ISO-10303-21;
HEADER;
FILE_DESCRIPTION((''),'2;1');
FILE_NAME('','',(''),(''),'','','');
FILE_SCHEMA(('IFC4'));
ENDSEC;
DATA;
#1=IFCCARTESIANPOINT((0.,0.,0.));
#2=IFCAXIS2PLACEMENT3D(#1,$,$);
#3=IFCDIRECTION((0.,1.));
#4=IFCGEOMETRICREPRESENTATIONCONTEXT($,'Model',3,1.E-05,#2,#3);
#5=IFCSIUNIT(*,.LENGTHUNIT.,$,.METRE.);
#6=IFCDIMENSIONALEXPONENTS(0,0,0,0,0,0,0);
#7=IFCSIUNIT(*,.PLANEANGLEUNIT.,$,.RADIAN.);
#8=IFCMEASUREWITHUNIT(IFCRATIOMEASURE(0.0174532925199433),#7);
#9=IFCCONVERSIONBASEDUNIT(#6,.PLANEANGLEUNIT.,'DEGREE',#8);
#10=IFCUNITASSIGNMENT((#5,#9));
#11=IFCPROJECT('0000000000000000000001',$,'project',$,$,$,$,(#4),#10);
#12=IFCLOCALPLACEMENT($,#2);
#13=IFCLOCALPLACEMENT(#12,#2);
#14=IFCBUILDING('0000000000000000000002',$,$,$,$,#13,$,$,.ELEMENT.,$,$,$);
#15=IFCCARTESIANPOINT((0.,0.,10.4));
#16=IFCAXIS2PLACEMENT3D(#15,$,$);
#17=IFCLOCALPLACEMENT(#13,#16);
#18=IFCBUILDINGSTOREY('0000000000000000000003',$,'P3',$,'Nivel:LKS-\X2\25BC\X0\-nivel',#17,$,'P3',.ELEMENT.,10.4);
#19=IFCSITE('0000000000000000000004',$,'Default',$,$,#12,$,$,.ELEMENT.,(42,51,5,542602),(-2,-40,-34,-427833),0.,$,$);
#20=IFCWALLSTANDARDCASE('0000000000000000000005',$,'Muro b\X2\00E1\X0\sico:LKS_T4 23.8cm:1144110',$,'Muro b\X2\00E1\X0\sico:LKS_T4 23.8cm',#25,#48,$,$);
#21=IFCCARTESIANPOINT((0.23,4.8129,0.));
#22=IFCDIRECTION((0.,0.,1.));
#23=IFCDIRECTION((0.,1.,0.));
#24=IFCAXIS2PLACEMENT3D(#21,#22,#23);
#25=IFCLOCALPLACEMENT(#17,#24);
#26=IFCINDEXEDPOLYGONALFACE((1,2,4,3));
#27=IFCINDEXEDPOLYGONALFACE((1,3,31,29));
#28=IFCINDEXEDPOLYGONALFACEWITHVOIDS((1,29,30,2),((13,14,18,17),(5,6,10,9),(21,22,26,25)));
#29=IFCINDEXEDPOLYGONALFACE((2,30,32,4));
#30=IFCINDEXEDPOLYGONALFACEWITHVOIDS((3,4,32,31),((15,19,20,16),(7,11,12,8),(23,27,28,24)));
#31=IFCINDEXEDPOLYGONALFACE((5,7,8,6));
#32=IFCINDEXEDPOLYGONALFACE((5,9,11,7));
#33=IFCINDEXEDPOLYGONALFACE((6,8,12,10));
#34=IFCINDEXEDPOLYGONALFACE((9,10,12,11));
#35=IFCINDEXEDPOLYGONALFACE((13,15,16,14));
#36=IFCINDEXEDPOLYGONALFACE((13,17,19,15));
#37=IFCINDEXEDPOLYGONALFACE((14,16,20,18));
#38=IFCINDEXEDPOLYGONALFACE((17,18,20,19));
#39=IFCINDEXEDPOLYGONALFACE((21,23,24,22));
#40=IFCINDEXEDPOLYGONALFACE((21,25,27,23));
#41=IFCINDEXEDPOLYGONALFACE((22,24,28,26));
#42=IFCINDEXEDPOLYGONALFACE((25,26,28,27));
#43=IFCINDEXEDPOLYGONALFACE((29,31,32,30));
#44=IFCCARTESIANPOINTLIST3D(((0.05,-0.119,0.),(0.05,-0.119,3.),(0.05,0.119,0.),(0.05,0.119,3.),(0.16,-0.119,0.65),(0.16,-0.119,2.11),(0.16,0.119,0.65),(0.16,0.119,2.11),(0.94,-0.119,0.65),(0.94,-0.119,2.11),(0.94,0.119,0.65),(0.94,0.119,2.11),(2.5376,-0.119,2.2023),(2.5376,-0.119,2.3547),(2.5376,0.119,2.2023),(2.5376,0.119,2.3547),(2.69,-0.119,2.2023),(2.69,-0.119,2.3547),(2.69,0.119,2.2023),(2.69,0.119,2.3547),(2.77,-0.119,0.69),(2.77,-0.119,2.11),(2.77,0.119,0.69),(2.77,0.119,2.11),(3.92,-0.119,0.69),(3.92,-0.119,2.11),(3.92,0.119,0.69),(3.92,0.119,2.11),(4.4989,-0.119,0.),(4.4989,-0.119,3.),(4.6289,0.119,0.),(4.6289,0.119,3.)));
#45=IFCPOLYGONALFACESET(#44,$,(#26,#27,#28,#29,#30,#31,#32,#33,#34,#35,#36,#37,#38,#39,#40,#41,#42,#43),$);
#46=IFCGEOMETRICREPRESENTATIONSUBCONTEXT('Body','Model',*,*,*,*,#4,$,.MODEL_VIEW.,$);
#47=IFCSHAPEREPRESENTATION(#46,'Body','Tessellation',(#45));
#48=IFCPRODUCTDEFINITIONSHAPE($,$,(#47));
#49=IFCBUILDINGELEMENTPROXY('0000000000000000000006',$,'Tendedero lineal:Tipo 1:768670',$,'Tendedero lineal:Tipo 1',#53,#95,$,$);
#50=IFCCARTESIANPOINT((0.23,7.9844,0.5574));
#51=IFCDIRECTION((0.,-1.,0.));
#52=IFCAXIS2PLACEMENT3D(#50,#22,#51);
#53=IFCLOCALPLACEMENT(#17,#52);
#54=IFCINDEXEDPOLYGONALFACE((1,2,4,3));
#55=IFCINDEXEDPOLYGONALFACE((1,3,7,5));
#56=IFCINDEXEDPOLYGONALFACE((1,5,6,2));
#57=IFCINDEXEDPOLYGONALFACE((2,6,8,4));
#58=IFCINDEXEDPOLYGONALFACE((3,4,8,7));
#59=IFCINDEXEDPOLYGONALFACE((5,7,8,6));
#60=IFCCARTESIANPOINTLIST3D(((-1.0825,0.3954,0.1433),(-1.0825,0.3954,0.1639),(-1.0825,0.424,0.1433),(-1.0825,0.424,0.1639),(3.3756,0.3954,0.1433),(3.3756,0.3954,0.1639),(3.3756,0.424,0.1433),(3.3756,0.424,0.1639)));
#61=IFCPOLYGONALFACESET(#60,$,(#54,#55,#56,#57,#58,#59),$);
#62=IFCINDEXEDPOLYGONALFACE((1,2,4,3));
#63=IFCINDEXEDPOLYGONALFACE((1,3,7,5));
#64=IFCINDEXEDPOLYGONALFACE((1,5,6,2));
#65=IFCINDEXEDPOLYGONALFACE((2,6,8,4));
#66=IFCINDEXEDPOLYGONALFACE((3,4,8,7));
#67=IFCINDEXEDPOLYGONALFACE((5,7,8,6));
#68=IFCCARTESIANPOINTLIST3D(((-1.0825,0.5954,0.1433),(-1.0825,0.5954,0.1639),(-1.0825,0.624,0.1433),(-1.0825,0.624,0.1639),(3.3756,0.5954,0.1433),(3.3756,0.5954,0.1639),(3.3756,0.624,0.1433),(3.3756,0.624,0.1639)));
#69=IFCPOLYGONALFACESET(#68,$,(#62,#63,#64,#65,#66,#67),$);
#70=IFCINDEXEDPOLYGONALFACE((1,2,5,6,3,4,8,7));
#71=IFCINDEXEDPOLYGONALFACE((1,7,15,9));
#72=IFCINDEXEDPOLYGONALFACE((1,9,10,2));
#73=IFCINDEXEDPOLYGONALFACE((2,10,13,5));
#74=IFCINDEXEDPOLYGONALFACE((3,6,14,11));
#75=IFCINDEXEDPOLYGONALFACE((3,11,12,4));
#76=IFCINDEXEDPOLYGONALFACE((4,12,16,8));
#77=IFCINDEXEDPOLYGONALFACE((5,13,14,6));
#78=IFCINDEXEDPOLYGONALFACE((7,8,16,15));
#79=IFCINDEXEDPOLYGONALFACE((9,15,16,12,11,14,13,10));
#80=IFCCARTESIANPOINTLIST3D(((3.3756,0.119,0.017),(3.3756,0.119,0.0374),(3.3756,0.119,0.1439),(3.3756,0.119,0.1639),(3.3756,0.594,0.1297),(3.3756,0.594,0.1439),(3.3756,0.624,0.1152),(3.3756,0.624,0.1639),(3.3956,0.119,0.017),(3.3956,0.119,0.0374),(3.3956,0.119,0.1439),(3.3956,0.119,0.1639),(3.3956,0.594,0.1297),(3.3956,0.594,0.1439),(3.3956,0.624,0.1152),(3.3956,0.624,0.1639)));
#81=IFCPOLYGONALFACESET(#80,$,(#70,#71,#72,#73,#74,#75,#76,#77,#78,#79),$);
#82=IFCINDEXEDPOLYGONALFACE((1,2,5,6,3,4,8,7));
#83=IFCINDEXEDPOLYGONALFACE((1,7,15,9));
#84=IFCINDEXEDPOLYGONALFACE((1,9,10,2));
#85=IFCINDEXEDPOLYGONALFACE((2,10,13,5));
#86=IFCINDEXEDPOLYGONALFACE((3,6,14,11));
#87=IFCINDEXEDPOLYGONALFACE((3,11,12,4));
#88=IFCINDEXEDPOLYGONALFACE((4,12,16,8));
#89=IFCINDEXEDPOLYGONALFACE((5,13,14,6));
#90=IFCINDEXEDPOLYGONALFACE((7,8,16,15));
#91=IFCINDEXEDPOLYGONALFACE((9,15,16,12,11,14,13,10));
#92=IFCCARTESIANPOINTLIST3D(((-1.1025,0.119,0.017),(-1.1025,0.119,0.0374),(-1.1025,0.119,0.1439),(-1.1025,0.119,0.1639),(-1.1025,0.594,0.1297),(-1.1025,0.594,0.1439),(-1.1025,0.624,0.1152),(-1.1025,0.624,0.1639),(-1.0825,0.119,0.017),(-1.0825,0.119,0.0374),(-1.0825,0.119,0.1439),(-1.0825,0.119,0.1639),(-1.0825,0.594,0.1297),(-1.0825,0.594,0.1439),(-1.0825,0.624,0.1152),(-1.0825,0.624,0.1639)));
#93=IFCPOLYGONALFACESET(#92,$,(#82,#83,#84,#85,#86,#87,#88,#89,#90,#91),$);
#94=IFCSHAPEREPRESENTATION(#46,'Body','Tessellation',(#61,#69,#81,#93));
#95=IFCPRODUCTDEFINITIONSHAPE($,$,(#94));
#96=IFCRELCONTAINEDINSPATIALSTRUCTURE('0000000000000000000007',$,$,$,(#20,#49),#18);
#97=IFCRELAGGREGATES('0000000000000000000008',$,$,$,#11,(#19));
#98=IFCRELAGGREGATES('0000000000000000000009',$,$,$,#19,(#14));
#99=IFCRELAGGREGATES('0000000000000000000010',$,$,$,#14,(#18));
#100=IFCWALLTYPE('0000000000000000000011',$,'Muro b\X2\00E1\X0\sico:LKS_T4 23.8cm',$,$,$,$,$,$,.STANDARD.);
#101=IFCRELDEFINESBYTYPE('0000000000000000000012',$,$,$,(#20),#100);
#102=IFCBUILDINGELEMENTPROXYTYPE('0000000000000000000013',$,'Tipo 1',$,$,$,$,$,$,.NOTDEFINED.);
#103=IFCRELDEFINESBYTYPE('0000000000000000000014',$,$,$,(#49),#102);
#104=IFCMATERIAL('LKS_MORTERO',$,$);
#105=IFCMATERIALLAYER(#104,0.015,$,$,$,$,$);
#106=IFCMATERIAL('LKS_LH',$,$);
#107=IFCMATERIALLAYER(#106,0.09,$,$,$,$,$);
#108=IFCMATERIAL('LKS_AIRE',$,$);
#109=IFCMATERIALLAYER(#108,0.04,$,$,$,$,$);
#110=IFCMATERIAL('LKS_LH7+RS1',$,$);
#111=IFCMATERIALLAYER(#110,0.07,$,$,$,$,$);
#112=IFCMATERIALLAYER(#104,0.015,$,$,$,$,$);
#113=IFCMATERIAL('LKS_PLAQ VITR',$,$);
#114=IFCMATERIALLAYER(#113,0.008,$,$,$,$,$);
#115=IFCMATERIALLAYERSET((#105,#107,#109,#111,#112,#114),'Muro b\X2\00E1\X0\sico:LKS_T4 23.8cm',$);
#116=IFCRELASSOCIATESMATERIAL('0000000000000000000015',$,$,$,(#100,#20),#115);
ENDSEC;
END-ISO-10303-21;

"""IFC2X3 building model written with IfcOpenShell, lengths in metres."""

from ifc_helpers import new_model, entity, si_unit, converted_unit, direction, frame, frame_2d, origin, origin_2d_with_axis, place, context, subcontext, project, spatial, polyline, rectangle, outline, extrude, source, transform, mapped, material, layer, layer_set, layer_usage, type_object, type_shapes, element, save


model = new_model("IFC2X3")

# Units and contexts
model_context = context("Model", 3, precision=1e-05, world=origin(), true_north=direction((0.0, 1.0)))
body_context = subcontext(model_context, "Body", "Model", "MODEL_VIEW")
ifc_project = project(units=[si_unit("LENGTHUNIT", "METRE"), converted_unit("PLANEANGLEUNIT", "DEGREE", entity("IfcRatioMeasure", 0.0174532925199433), si_unit("PLANEANGLEUNIT", "RADIAN"), dimensions=[0, 0, 0, 0, 0, 0, 0])], contexts=[model_context])

# Site, building, storey
site_placement = place(None, origin())
site = spatial("IfcSite", under=ifc_project, at=site_placement, Name="Default", CompositionType="ELEMENT", RefLatitude=(42, 51, 5, 542602), RefLongitude=(-2, -40, -34, -427833), RefElevation=0.0)
building_placement = place(site_placement, origin())
building = spatial("IfcBuilding", under=site, at=building_placement, CompositionType="ELEMENT")
storey_placement = place(building_placement, frame((0.0, 0.0, 10.4)))
storey = spatial("IfcBuildingStorey", under=building, at=storey_placement, Name="P3", ObjectType="Nivel:LKS-▼-nivel", LongName="P3", CompositionType="ELEMENT", Elevation=10.4)

# Shared definitions
ifc_material_1 = material(Name="LKS_MORTERO")
ifc_material_2 = material(Name="LKS_PLAQ VITR")

# Shared definitions
ifc_layer_1 = layer(ifc_material_1, 0.015)
ifc_material_3 = material(Name="LKS_LH")
ifc_layer_2 = layer(ifc_material_3, 0.09)
ifc_material_4 = material(Name="LKS_AIRE")
ifc_layer_3 = layer(ifc_material_4, 0.04)
ifc_material_5 = material(Name="LKS_LH7+RS1")
ifc_layer_4 = layer(ifc_material_5, 0.07)
ifc_layer_5 = layer(ifc_material_1, 0.015)
ifc_layer_6 = layer(ifc_material_2, 0.008)
ifc_layer_set_1 = layer_set([ifc_layer_1, ifc_layer_2, ifc_layer_3, ifc_layer_4, ifc_layer_5, ifc_layer_6], Name="Muro básico:LKS_T4 23.8cm")
wall_type_1 = type_object("IfcWallType", Name="Muro básico:LKS_T4 23.8cm", PredefinedType="STANDARD", material=ifc_layer_set_1)

# Wall, openings
ifc_layer_usage_1 = layer_usage(ifc_layer_set_1, "AXIS2", "NEGATIVE", 0.119)
wall_1_placement = place(storey_placement, frame((0.23, 4.8129, 0.0), z_axis=(0.0, 0.0, 1.0), x_axis=(0.0, 1.0, 0.0)))
wall_1 = element("IfcWallStandardCase", 1, at=wall_1_placement, inside=storey, type_object=wall_type_1, material=ifc_layer_usage_1, Name="Muro básico:LKS_T4 23.8cm:1144110", ObjectType="Muro básico:LKS_T4 23.8cm", context=body_context, shape_type="SweptSolid", body=[
    extrude(outline(polyline([(4.4989, -0.119), (4.6289, 0.119), (4.4489, 0.119), (1.85, 0.119), (1.75, 0.119), (0.05, 0.119), (0.05, 0.111), (0.05, -0.119), (4.4989, -0.119)])), origin(), (0.0, 0.0, 1.0), 3.0),
])
opening_1_placement = place(wall_1_placement, origin())
element("IfcOpeningElement", 2, at=opening_1_placement, cuts=wall_1, ObjectType="Opening", context=body_context, shape_type="SweptSolid", body=[
    extrude(rectangle(XDim=0.1524, YDim=0.1524, at=frame_2d((0.0, 0.0), x_axis=(0.0, 1.0))), frame((2.6138, -1.405, 2.2785), z_axis=(0.0, 1.0, 0.0), x_axis=(-1.0, 0.0, 0.0)), (0.0, 0.0, 1.0), 3.048),
])
opening_2_placement = place(wall_1_placement, frame((3.92, 0.119, 0.69)))
element("IfcOpeningElement", 3, at=opening_2_placement, cuts=wall_1, ObjectType="Opening", context=body_context, shape_type="SweptSolid", body=[
    extrude(rectangle(XDim=1.42, YDim=1.15, at=frame_2d((0.71, 0.575), x_axis=(1.0, 0.0))), frame((0.0, 0.0, 0.0), z_axis=(0.0, -1.0, 0.0), x_axis=(0.0, 0.0, 1.0)), (0.0, 0.0, 1.0), 0.238),
])
opening_3_placement = place(wall_1_placement, frame((0.16, -0.119, 0.65)))
element("IfcOpeningElement", 4, at=opening_3_placement, cuts=wall_1, ObjectType="Opening", context=body_context, shape_type="SweptSolid", body=[
    extrude(rectangle(XDim=1.46, YDim=0.78, at=frame_2d((0.73, 0.39), x_axis=(1.0, 0.0))), frame((0.0, 0.0, 0.0), z_axis=(0.0, 1.0, 0.0), x_axis=(0.0, 0.0, 1.0)), (0.0, 0.0, 1.0), 0.238),
])

# Building element proxy
building_element_proxy_type_1 = type_object("IfcBuildingElementProxyType", Name="Tipo 1", PredefinedType="NOTDEFINED")
shared_shape_1 = source(origin(), body_context, "Body", "SweptSolid", [
    extrude(rectangle(XDim=4.4581, YDim=0.0286, at=origin_2d_with_axis()), frame((1.1466, 0.4097, 0.1433), z_axis=(0.0, 0.0, 1.0), x_axis=(-1.0, 0.0, 0.0)), (0.0, 0.0, 1.0), 0.0206),
    extrude(rectangle(XDim=4.4581, YDim=0.0286, at=origin_2d_with_axis()), frame((1.1466, 0.6097, 0.1433), z_axis=(0.0, 0.0, 1.0), x_axis=(-1.0, 0.0, 0.0)), (0.0, 0.0, 1.0), 0.0206),
    extrude(outline(polyline([(-0.26, -0.0495), (0.245, -0.0495), (0.245, -0.0295), (-0.23, -0.0295), (-0.23, -0.0154), (0.245, 0.077), (0.245, 0.0973), (-0.26, -0.0008), (-0.26, -0.0495)])), frame((3.3756, 0.364, 0.1144), z_axis=(1.0, 0.0, 0.0), x_axis=(0.0, -1.0, 0.0)), (0.0, 0.0, 1.0), 0.02),
    extrude(outline(polyline([(-0.26, -0.0495), (0.245, -0.0495), (0.245, -0.0295), (-0.23, -0.0295), (-0.23, -0.0154), (0.245, 0.077), (0.245, 0.0973), (-0.26, -0.0008), (-0.26, -0.0495)])), frame((-1.1025, 0.364, 0.1144), z_axis=(1.0, 0.0, 0.0), x_axis=(0.0, -1.0, 0.0)), (0.0, 0.0, 1.0), 0.02),
])
type_shapes(building_element_proxy_type_1, [shared_shape_1])
proxy_1_placement = place(storey_placement, frame((0.23, 7.9844, 0.5574), z_axis=(0.0, 0.0, 1.0), x_axis=(0.0, -1.0, 0.0)))
element("IfcBuildingElementProxy", 5, at=proxy_1_placement, inside=storey, type_object=building_element_proxy_type_1, Name="Tendedero lineal:Tipo 1:768670", ObjectType="Tendedero lineal:Tipo 1", context=body_context, shape_type="MappedRepresentation", body=[
    mapped(shared_shape_1, transform((0.0, 0.0, 0.0), scale=1.0)),
])

save(model, "model.ifc")
